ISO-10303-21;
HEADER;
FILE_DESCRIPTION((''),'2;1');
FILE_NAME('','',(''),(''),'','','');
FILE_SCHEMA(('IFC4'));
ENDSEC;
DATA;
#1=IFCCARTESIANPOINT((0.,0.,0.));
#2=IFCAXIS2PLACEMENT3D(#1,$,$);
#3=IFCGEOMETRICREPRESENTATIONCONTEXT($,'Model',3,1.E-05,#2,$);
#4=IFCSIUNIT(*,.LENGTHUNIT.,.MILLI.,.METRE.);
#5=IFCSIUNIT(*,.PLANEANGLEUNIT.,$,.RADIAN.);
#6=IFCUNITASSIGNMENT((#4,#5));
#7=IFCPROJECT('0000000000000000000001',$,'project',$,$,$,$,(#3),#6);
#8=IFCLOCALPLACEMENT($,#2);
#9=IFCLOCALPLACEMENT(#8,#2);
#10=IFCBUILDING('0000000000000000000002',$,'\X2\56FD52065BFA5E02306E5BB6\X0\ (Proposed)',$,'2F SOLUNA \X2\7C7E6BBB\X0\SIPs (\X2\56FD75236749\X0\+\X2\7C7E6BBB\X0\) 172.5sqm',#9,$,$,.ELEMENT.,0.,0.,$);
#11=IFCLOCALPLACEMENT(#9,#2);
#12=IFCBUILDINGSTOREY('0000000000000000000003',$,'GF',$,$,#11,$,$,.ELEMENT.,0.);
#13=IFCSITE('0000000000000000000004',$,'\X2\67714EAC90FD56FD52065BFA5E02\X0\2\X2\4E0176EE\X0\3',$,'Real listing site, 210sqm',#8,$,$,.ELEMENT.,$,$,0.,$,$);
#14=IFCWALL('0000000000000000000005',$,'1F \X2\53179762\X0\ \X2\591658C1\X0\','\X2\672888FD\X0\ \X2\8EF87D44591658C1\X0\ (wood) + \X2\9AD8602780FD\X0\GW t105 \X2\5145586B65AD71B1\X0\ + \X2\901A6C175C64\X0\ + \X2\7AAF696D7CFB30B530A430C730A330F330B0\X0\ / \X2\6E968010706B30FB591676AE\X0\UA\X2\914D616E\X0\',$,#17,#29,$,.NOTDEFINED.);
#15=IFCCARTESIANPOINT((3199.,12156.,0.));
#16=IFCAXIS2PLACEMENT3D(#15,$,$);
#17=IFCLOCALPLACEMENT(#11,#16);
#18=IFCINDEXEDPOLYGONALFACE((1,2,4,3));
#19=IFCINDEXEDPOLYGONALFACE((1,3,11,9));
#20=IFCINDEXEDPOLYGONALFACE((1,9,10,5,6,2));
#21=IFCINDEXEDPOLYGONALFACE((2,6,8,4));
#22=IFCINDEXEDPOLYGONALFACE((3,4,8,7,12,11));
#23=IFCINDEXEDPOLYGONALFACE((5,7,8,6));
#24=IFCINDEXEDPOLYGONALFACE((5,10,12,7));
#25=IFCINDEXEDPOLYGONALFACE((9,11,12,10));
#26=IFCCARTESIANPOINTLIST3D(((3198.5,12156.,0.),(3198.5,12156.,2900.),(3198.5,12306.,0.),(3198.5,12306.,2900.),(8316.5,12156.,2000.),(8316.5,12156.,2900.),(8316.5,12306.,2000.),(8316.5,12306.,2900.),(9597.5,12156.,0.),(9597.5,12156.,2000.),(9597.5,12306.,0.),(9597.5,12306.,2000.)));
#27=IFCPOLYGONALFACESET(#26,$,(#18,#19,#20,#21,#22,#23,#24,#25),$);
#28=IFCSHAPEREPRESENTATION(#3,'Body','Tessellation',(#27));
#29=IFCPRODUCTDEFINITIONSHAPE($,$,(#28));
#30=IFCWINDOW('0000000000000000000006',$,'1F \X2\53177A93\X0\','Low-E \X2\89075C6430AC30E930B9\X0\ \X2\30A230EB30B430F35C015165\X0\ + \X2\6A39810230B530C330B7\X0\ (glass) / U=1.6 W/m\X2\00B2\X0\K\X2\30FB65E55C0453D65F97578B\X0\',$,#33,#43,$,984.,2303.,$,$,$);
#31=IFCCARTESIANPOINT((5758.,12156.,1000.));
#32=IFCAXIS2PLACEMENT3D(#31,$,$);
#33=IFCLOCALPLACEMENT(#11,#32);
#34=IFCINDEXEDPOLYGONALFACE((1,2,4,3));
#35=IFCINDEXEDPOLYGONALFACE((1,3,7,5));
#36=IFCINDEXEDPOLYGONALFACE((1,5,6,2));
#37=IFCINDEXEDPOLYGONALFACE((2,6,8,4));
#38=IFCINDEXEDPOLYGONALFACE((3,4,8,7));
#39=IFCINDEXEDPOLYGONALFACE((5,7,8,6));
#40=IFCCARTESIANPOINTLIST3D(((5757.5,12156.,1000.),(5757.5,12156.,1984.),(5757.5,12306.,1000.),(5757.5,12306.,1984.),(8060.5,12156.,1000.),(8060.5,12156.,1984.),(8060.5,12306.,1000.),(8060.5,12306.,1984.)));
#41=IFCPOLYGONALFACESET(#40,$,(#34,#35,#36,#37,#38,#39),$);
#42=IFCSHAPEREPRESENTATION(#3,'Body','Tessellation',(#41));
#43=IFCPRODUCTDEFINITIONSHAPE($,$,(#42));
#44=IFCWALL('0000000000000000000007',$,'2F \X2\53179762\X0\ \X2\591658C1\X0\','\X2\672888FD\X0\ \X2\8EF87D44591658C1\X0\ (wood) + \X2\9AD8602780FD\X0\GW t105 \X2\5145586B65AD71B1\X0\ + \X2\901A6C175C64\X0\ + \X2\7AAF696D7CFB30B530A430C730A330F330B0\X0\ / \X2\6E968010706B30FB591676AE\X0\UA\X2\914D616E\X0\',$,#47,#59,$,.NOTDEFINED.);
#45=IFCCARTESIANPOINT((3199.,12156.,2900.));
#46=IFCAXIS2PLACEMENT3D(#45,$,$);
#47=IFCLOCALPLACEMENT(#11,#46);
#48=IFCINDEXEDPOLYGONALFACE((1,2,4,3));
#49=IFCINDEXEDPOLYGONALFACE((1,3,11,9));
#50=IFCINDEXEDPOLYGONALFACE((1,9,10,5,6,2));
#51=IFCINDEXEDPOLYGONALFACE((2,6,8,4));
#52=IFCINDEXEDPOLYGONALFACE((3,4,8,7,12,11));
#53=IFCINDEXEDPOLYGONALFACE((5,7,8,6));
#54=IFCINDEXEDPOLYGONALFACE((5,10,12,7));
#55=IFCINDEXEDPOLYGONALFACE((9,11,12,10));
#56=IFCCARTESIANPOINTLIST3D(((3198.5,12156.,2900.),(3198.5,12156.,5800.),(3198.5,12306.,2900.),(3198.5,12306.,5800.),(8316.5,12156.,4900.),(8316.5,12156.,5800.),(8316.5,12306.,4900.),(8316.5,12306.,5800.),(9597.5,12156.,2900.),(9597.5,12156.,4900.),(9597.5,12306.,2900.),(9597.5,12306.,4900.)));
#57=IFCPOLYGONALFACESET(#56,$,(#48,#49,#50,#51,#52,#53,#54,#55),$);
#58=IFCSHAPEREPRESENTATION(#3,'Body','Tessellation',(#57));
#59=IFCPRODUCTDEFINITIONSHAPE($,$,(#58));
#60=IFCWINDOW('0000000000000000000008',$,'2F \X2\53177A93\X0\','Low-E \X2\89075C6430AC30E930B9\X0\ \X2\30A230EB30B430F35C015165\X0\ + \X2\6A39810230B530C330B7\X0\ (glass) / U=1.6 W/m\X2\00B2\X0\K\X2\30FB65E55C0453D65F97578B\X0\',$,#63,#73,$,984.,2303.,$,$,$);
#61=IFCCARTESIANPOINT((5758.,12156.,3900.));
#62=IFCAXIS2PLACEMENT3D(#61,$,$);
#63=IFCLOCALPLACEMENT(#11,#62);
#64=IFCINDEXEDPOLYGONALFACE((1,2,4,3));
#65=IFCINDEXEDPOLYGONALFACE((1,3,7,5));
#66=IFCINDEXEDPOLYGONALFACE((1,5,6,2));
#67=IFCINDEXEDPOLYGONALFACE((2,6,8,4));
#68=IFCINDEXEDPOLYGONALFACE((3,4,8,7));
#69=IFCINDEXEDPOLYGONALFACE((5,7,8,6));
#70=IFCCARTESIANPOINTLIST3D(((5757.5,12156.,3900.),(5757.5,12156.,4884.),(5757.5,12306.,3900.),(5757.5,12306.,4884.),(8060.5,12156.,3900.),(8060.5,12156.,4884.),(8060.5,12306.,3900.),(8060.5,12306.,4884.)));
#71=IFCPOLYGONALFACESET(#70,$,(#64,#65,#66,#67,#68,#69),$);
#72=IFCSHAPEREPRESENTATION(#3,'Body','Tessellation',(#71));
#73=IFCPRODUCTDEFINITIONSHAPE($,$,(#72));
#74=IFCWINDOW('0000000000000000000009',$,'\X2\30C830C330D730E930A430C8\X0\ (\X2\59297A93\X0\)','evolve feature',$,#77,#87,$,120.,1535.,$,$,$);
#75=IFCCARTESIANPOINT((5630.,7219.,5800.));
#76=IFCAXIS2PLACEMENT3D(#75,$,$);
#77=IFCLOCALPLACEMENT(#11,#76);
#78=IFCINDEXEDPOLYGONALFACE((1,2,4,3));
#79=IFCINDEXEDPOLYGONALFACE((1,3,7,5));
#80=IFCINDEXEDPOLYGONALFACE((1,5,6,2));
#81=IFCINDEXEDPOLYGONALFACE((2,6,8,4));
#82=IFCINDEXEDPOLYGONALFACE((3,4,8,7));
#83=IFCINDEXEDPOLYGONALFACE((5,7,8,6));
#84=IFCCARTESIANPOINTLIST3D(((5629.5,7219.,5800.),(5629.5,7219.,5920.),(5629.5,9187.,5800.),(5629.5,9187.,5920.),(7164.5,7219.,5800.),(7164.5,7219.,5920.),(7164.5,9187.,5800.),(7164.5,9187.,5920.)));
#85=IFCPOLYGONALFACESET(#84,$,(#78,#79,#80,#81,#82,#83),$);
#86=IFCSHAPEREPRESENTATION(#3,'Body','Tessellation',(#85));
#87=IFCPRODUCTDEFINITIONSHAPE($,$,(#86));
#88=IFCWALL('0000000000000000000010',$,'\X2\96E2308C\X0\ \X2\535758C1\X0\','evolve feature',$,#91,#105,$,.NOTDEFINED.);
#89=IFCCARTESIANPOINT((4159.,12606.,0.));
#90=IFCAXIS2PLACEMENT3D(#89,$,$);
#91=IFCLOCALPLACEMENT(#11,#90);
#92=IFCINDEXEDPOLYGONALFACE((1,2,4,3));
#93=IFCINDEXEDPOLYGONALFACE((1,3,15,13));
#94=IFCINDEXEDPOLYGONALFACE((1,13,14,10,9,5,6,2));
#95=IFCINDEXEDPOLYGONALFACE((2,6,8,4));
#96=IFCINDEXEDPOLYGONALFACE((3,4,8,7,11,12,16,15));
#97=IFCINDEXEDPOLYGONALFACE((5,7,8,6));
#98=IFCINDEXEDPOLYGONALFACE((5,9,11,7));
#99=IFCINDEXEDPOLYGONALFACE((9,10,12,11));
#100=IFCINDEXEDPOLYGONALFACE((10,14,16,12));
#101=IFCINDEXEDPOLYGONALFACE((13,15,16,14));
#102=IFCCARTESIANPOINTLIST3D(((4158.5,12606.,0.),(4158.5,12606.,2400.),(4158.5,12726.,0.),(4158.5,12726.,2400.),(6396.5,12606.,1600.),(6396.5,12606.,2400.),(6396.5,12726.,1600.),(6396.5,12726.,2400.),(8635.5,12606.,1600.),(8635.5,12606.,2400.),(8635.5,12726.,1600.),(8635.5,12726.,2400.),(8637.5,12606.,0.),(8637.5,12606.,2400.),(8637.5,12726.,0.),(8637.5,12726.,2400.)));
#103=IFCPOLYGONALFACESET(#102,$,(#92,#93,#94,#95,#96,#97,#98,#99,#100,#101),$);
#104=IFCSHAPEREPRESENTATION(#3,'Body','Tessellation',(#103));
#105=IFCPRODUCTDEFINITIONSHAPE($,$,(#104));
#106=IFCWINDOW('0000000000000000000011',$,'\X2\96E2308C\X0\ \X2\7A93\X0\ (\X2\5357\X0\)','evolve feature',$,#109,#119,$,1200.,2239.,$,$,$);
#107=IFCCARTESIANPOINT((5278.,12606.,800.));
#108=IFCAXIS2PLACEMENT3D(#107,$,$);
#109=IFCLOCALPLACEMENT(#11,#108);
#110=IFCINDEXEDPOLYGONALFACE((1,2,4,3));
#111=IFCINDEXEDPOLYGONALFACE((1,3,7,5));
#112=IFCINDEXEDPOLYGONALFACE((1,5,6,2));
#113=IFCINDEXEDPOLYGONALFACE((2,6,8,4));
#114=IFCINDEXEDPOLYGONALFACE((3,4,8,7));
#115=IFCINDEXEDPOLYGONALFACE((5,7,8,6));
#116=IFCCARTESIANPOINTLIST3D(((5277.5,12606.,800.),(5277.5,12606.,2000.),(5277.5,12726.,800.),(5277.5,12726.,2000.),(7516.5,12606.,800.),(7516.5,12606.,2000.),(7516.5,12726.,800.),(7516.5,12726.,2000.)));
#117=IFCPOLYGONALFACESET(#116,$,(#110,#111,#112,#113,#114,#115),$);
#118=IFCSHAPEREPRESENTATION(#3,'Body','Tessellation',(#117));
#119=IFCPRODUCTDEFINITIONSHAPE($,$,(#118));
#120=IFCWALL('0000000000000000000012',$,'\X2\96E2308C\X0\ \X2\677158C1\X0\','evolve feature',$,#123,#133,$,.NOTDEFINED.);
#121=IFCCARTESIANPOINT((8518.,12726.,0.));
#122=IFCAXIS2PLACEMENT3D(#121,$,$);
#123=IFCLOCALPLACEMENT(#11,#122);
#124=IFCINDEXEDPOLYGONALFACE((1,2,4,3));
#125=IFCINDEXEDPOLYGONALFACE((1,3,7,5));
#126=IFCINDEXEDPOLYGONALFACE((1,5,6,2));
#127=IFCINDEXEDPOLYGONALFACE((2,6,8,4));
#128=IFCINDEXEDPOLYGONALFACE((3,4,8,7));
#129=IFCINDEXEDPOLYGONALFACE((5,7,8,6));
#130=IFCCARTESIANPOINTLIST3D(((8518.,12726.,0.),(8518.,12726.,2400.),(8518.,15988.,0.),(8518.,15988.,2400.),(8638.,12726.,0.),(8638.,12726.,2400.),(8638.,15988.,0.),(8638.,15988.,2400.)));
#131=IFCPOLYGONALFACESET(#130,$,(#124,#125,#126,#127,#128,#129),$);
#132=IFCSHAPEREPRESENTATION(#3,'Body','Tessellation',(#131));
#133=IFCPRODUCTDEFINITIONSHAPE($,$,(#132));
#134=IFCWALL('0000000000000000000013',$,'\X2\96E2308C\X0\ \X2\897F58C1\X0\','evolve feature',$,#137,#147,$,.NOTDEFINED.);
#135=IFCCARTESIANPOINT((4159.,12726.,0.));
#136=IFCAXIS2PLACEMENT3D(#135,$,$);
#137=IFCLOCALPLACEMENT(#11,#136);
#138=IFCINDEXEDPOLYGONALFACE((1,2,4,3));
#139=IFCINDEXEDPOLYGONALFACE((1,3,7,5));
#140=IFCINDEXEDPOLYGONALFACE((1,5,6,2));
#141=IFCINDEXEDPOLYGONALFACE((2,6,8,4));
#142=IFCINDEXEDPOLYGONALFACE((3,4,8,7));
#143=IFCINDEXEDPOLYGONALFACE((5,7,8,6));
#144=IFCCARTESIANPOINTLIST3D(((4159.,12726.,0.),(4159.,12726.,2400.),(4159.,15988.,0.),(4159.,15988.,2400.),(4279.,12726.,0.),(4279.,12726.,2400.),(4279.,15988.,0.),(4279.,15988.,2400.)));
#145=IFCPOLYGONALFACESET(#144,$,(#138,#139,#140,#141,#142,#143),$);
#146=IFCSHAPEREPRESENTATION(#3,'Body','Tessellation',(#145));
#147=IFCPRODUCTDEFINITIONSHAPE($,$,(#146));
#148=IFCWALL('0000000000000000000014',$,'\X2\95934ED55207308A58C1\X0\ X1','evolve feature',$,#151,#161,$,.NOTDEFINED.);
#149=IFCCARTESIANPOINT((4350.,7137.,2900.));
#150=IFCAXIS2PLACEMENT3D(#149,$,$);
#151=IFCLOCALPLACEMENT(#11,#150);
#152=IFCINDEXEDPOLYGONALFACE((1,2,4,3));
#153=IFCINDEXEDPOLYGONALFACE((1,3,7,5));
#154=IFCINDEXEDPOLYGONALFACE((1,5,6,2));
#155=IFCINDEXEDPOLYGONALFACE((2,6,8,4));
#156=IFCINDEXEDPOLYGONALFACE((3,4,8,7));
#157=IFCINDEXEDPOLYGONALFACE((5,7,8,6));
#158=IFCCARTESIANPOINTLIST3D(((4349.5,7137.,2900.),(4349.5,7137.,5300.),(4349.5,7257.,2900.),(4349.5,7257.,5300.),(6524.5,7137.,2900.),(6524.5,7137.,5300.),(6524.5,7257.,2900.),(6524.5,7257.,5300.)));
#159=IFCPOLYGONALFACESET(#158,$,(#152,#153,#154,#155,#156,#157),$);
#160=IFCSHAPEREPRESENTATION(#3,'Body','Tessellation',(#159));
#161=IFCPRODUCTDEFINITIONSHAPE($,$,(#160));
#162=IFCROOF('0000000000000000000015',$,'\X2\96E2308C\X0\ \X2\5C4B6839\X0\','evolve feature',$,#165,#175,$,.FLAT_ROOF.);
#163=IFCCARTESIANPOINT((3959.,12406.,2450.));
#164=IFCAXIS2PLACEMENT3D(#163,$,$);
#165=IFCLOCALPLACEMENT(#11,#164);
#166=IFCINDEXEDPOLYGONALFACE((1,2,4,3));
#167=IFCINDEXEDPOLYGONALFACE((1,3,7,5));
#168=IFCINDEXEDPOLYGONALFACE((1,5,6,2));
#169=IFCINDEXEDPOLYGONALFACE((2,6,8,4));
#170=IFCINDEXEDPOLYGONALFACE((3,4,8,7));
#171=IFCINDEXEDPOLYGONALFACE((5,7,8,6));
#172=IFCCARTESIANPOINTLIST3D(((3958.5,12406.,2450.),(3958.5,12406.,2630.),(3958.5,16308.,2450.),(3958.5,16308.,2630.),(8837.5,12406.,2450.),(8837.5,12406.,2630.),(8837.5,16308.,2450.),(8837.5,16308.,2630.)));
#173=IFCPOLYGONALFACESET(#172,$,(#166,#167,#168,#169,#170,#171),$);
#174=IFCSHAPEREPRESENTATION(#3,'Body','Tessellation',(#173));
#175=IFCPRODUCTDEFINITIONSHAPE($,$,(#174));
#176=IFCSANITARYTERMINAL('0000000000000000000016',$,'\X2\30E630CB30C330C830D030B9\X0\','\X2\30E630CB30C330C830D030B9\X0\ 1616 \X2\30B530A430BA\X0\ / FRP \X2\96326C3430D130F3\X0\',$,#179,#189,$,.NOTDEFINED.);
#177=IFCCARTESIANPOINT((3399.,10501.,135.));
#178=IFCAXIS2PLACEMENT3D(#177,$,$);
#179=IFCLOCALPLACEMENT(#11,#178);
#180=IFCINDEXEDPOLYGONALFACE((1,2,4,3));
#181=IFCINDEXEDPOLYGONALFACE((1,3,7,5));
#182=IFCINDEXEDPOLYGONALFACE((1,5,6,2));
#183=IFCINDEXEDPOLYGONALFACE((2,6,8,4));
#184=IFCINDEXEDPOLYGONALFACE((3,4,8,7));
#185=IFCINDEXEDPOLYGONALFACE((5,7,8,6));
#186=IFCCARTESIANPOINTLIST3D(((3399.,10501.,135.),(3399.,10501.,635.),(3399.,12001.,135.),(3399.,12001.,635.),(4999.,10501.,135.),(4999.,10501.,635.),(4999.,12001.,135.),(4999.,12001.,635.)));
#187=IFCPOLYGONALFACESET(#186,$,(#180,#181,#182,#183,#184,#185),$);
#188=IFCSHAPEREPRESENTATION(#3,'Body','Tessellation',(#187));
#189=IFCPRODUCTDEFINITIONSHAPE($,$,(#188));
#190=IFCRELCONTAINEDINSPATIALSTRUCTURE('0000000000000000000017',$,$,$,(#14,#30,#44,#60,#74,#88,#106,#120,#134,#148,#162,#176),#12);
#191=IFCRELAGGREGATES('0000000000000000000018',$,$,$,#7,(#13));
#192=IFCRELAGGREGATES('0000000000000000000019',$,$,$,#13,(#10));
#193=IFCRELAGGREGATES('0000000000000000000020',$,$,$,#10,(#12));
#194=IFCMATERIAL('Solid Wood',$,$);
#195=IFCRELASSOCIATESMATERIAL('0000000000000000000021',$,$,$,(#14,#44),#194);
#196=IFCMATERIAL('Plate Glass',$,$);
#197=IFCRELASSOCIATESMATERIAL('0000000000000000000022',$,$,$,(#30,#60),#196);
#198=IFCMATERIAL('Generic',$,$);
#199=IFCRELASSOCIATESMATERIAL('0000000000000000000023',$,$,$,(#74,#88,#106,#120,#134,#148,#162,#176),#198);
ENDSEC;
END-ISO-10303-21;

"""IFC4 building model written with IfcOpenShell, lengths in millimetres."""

from ifc_helpers import new_model, si_unit, frame, frame_2d, origin, place, context, project, spatial, rectangle, extrude, material, element, fill, save


model = new_model("IFC4")

# Units and contexts
model_context = context("Model", 3, precision=1e-05, world=origin())
ifc_project = project(units=[si_unit("LENGTHUNIT", "METRE", prefix="MILLI"), si_unit("PLANEANGLEUNIT", "RADIAN")], contexts=[model_context])

# Site, building, storey
site_placement = place(None, origin())
site = spatial("IfcSite", under=ifc_project, at=site_placement, Name="東京都国分寺市2丁目3", ObjectType="Real listing site, 210sqm", CompositionType="ELEMENT", RefElevation=0.0)
building_placement = place(site_placement, origin())
building = spatial("IfcBuilding", under=site, at=building_placement, Name="国分寺市の家 (Proposed)", ObjectType="2F SOLUNA 籾殻SIPs (国産杉+籾殻) 172.5sqm", CompositionType="ELEMENT", ElevationOfRefHeight=0.0, ElevationOfTerrain=0.0)
storey_placement = place(building_placement, origin())
storey = spatial("IfcBuildingStorey", under=building, at=storey_placement, Name="GF", CompositionType="ELEMENT", Elevation=0.0)

# Shared definitions
ifc_material_1 = material(Name="Generic")

# Wall, opening, window
ifc_material_2 = material(Name="Solid Wood")
wall_1_placement = place(storey_placement, frame((3199.0, 12156.0, 0.0)))
wall_1 = element("IfcWall", 1, at=wall_1_placement, inside=storey, material=ifc_material_2, Name="1F 北面 外壁", Description="木製 軸組外壁 (wood) + 高性能GW t105 充填断熱 + 通気層 + 窯業系サイディング / 準耐火・外皮UA配慮", PredefinedType="NOTDEFINED", context=model_context, shape_type="SweptSolid", body=[
    extrude(rectangle(XDim=6399.0, YDim=150.0, at=frame_2d((3199.0, 75.0))), frame((3199.0, 12156.0, 0.0)), (0.0, 0.0, 1.0), 2900.0),
])
opening_1_placement = place(storey_placement, frame((5758.0, 12156.0, 1000.0)))
opening_1 = element("IfcOpeningElement", 2, at=opening_1_placement, cuts=wall_1, PredefinedType="NOTDEFINED", context=model_context, shape_type="SweptSolid", body=[
    extrude(rectangle(XDim=2303.0, YDim=150.0, at=frame_2d((1151.0, 75.0))), frame((5758.0, 12156.0, 1000.0)), (0.0, 0.0, 1.0), 984.0),
])
ifc_material_3 = material(Name="Plate Glass")
window_1_placement = place(storey_placement, frame((5758.0, 12156.0, 1000.0)))
window_1 = element("IfcWindow", 3, at=window_1_placement, inside=storey, material=ifc_material_3, Name="1F 北窓", Description="Low-E 複層ガラス アルゴン封入 + 樹脂サッシ (glass) / U=1.6 W/m²K・日射取得型", OverallHeight=984.0, OverallWidth=2303.0, context=model_context, shape_type="SweptSolid", body=[
    extrude(rectangle(XDim=2303.0, YDim=150.0, at=frame_2d((1151.0, 75.0))), frame((5758.0, 12156.0, 1000.0)), (0.0, 0.0, 1.0), 984.0),
])
fill(opening_1, window_1)

# Wall, opening, window
wall_2_placement = place(storey_placement, frame((3199.0, 12156.0, 2900.0)))
wall_2 = element("IfcWall", 4, at=wall_2_placement, inside=storey, material=ifc_material_2, Name="2F 北面 外壁", Description="木製 軸組外壁 (wood) + 高性能GW t105 充填断熱 + 通気層 + 窯業系サイディング / 準耐火・外皮UA配慮", PredefinedType="NOTDEFINED", context=model_context, shape_type="SweptSolid", body=[
    extrude(rectangle(XDim=6399.0, YDim=150.0, at=frame_2d((3199.0, 75.0))), frame((3199.0, 12156.0, 2900.0)), (0.0, 0.0, 1.0), 2900.0),
])
opening_2_placement = place(storey_placement, frame((5758.0, 12156.0, 3900.0)))
opening_2 = element("IfcOpeningElement", 5, at=opening_2_placement, cuts=wall_2, PredefinedType="NOTDEFINED", context=model_context, shape_type="SweptSolid", body=[
    extrude(rectangle(XDim=2303.0, YDim=150.0, at=frame_2d((1151.0, 75.0))), frame((5758.0, 12156.0, 3900.0)), (0.0, 0.0, 1.0), 984.0),
])
window_2_placement = place(storey_placement, frame((5758.0, 12156.0, 3900.0)))
window_2 = element("IfcWindow", 6, at=window_2_placement, inside=storey, material=ifc_material_3, Name="2F 北窓", Description="Low-E 複層ガラス アルゴン封入 + 樹脂サッシ (glass) / U=1.6 W/m²K・日射取得型", OverallHeight=984.0, OverallWidth=2303.0, context=model_context, shape_type="SweptSolid", body=[
    extrude(rectangle(XDim=2303.0, YDim=150.0, at=frame_2d((1151.0, 75.0))), frame((5758.0, 12156.0, 3900.0)), (0.0, 0.0, 1.0), 984.0),
])
fill(opening_2, window_2)

# Window
window_3_placement = place(storey_placement, frame((5630.0, 7219.0, 5800.0)))
element("IfcWindow", 7, at=window_3_placement, inside=storey, material=ifc_material_1, Name="トップライト (天窓)", Description="evolve feature", OverallHeight=120.0, OverallWidth=1535.0, context=model_context, shape_type="SweptSolid", body=[
    extrude(rectangle(XDim=1535.0, YDim=1968.0, at=frame_2d((767.0, 984.0))), frame((5630.0, 7219.0, 5800.0)), (0.0, 0.0, 1.0), 120.0),
])

# Wall, opening, window
wall_3_placement = place(storey_placement, frame((4159.0, 12606.0, 0.0)))
wall_3 = element("IfcWall", 8, at=wall_3_placement, inside=storey, material=ifc_material_1, Name="離れ 南壁", Description="evolve feature", PredefinedType="NOTDEFINED", context=model_context, shape_type="SweptSolid", body=[
    extrude(rectangle(XDim=4479.0, YDim=120.0, at=frame_2d((2239.0, 60.0))), frame((4159.0, 12606.0, 0.0)), (0.0, 0.0, 1.0), 2400.0),
])
opening_3_placement = place(storey_placement, frame((5278.0, 12606.0, 800.0)))
opening_3 = element("IfcOpeningElement", 9, at=opening_3_placement, cuts=wall_3, PredefinedType="NOTDEFINED", context=model_context, shape_type="SweptSolid", body=[
    extrude(rectangle(XDim=2239.0, YDim=120.0, at=frame_2d((1119.0, 60.0))), frame((5278.0, 12606.0, 800.0)), (0.0, 0.0, 1.0), 1200.0),
])
window_4_placement = place(storey_placement, frame((5278.0, 12606.0, 800.0)))
window_4 = element("IfcWindow", 10, at=window_4_placement, inside=storey, material=ifc_material_1, Name="離れ 窓 (南)", Description="evolve feature", OverallHeight=1200.0, OverallWidth=2239.0, context=model_context, shape_type="SweptSolid", body=[
    extrude(rectangle(XDim=2239.0, YDim=120.0, at=frame_2d((1119.0, 60.0))), frame((5278.0, 12606.0, 800.0)), (0.0, 0.0, 1.0), 1200.0),
])
fill(opening_3, window_4)

# Walls
wall_4_placement = place(storey_placement, frame((8518.0, 12726.0, 0.0)))
element("IfcWall", 11, at=wall_4_placement, inside=storey, material=ifc_material_1, Name="離れ 東壁", Description="evolve feature", PredefinedType="NOTDEFINED", context=model_context, shape_type="SweptSolid", body=[
    extrude(rectangle(XDim=120.0, YDim=3262.0, at=frame_2d((60.0, 1631.0))), frame((8518.0, 12726.0, 0.0)), (0.0, 0.0, 1.0), 2400.0),
])
wall_5_placement = place(storey_placement, frame((4159.0, 12726.0, 0.0)))
element("IfcWall", 12, at=wall_5_placement, inside=storey, material=ifc_material_1, Name="離れ 西壁", Description="evolve feature", PredefinedType="NOTDEFINED", context=model_context, shape_type="SweptSolid", body=[
    extrude(rectangle(XDim=120.0, YDim=3262.0, at=frame_2d((60.0, 1631.0))), frame((4159.0, 12726.0, 0.0)), (0.0, 0.0, 1.0), 2400.0),
])
wall_6_placement = place(storey_placement, frame((4350.0, 7137.0, 2900.0)))
element("IfcWall", 13, at=wall_6_placement, inside=storey, material=ifc_material_1, Name="間仕切り壁 X1", Description="evolve feature", PredefinedType="NOTDEFINED", context=model_context, shape_type="SweptSolid", body=[
    extrude(rectangle(XDim=2175.0, YDim=120.0, at=frame_2d((1087.0, 60.0))), frame((4350.0, 7137.0, 2900.0)), (0.0, 0.0, 1.0), 2400.0),
])

# Roof
roof_placement = place(storey_placement, frame((3959.0, 12406.0, 2450.0)))
element("IfcRoof", 14, at=roof_placement, inside=storey, material=ifc_material_1, Name="離れ 屋根", Description="evolve feature", PredefinedType="FLAT_ROOF", context=model_context, shape_type="SweptSolid", body=[
    extrude(rectangle(XDim=4879.0, YDim=3902.0, at=frame_2d((2439.0, 1951.0))), frame((3959.0, 12406.0, 2450.0)), (0.0, 0.0, 1.0), 180.0),
])

# Sanitary terminal
sanitary_terminal_1_placement = place(storey_placement, frame((3399.0, 10501.0, 135.0)))
element("IfcSanitaryTerminal", 15, at=sanitary_terminal_1_placement, inside=storey, material=ifc_material_1, Name="ユニットバス", Description="ユニットバス 1616 サイズ / FRP 防水パン", PredefinedType="NOTDEFINED", context=model_context, shape_type="SweptSolid", body=[
    extrude(rectangle(XDim=1600.0, YDim=1500.0, at=frame_2d((800.0, 750.0))), frame((3399.0, 10501.0, 135.0)), (0.0, 0.0, 1.0), 500.0),
])

save(model, "model.ifc")
